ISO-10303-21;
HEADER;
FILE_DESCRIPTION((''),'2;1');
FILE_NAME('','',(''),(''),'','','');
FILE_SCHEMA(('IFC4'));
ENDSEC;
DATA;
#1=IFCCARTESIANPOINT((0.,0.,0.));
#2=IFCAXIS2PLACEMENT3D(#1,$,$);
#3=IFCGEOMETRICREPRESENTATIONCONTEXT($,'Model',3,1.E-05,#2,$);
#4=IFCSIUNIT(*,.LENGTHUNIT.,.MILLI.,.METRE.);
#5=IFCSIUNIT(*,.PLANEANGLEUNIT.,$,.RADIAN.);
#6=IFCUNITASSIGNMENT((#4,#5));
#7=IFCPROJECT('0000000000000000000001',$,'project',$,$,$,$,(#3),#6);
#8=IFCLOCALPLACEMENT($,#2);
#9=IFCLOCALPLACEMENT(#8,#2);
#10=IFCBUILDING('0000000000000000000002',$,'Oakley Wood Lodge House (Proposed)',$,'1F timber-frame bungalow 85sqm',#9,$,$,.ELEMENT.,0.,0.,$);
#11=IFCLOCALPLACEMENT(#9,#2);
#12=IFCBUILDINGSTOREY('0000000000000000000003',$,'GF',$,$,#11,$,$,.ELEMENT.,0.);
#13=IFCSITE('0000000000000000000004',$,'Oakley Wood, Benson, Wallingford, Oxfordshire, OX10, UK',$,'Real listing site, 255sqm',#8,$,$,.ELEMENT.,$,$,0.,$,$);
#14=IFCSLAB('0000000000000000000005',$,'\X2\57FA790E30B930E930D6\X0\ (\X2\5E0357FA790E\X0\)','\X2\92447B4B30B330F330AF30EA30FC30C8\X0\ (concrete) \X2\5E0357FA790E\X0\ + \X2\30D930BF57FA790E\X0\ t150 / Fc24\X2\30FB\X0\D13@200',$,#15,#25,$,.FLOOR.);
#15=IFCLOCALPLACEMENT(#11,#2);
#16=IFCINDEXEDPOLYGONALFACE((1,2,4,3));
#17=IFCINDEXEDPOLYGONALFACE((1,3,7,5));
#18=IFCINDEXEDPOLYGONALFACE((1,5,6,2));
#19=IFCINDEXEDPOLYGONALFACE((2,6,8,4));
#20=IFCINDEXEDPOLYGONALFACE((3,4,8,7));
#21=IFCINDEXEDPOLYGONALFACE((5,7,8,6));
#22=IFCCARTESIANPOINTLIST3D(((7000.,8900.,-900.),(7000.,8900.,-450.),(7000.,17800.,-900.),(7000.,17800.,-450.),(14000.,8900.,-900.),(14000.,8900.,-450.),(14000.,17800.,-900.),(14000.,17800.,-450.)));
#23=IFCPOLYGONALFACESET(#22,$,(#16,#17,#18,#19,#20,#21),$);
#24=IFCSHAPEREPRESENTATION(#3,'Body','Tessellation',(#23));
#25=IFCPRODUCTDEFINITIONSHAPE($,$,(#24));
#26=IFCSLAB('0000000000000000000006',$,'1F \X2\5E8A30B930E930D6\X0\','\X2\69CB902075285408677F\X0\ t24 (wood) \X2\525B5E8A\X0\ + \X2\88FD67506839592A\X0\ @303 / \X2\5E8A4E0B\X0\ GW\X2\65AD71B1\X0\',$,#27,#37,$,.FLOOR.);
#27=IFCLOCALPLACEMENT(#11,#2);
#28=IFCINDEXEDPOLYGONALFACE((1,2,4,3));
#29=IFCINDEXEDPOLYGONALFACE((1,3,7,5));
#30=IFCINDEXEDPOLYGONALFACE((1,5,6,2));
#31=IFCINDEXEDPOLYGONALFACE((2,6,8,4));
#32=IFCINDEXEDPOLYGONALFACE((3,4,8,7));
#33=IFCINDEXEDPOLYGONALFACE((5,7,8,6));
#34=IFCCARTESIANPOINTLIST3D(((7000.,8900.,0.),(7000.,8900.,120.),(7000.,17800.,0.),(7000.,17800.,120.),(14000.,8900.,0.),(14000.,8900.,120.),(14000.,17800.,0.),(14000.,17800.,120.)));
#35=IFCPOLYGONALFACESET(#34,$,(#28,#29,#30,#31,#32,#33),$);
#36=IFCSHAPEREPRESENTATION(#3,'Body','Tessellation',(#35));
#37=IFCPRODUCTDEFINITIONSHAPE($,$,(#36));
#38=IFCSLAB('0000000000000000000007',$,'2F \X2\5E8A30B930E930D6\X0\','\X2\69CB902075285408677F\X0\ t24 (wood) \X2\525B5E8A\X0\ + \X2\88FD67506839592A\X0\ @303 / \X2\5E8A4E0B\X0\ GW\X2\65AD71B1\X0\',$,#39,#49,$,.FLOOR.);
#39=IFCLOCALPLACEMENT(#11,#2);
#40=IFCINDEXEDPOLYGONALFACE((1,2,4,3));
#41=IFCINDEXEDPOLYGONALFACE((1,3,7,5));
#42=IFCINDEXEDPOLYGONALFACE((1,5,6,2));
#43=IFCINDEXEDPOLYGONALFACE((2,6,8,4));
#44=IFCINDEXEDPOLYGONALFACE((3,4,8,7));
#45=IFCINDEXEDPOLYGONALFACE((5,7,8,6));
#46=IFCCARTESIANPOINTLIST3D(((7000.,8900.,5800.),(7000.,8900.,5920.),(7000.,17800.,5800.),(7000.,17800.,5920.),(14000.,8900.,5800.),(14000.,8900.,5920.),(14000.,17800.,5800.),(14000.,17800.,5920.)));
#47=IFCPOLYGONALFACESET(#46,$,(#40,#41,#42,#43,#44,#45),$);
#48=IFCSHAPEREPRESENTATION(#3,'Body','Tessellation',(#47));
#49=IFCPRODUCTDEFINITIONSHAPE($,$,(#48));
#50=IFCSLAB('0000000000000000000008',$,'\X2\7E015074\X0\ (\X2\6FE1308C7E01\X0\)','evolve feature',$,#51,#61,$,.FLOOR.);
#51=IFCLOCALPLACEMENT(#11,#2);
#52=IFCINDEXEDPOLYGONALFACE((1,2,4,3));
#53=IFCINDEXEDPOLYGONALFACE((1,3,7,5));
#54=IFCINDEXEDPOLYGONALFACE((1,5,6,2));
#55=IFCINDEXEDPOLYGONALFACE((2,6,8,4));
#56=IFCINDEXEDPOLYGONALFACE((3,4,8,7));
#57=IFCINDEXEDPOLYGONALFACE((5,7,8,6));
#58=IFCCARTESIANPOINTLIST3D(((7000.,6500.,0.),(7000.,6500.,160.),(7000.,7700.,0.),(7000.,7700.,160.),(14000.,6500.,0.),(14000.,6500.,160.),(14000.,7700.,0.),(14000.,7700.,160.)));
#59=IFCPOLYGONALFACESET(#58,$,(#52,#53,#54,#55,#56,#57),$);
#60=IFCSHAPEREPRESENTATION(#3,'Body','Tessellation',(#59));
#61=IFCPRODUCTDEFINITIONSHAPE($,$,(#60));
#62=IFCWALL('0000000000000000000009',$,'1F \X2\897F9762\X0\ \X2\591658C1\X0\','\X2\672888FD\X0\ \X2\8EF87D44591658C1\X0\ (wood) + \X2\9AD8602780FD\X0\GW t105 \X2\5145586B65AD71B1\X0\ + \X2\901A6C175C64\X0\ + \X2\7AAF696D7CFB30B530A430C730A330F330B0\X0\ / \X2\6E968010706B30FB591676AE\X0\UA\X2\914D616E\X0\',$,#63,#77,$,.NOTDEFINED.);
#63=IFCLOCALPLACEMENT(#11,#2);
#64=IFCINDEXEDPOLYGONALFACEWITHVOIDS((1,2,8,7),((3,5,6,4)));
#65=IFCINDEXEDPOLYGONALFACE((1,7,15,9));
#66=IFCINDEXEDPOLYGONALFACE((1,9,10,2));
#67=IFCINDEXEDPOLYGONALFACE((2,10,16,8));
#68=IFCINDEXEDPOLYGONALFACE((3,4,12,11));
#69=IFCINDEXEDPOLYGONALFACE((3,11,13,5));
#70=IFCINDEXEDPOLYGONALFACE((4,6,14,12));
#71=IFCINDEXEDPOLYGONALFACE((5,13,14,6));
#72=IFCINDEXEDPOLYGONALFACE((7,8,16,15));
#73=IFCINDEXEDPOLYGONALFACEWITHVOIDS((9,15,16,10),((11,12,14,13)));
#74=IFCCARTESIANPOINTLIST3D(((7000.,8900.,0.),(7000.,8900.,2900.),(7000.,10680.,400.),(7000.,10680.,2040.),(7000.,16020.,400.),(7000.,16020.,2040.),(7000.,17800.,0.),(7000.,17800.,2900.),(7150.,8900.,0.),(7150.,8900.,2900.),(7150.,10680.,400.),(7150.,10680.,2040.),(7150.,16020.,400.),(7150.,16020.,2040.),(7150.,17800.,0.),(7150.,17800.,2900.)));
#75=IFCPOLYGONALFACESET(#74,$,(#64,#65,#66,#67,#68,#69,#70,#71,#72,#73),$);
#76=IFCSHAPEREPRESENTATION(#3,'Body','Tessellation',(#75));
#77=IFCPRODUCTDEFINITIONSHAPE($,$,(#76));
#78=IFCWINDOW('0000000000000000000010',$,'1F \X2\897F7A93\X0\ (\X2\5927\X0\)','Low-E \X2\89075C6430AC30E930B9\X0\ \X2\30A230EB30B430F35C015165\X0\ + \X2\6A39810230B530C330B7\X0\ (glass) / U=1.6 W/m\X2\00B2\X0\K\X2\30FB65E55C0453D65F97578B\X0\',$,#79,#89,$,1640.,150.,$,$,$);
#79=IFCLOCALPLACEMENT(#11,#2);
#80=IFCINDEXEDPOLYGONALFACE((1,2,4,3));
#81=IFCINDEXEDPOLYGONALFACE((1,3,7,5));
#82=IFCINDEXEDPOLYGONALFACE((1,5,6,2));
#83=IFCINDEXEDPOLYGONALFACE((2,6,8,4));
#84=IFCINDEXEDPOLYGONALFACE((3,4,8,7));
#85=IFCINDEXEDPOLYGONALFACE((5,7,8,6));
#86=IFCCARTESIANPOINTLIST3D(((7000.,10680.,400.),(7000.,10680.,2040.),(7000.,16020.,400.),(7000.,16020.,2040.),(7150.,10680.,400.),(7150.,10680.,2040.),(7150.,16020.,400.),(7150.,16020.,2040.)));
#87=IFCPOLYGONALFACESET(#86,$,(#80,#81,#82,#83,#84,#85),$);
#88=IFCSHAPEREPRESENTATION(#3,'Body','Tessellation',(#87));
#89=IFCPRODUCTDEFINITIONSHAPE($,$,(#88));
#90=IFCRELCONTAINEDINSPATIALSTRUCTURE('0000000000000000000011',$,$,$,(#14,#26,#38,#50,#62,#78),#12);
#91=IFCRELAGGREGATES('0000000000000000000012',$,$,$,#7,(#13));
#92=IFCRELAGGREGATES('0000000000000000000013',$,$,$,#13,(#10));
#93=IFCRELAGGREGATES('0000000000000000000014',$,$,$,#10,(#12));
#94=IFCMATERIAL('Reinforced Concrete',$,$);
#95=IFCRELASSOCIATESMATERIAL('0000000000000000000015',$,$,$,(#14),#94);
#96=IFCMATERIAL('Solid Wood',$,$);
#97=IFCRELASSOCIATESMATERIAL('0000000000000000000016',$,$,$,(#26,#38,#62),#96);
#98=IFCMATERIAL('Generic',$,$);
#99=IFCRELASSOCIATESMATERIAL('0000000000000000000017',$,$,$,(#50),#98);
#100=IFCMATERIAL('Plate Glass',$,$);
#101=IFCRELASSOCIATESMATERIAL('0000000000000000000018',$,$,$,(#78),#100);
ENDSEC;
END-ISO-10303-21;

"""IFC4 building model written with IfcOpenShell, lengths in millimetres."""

from ifc_helpers import new_model, si_unit, frame, frame_2d, origin, place, context, project, spatial, rectangle, extrude, material, element, fill, save


model = new_model("IFC4")

# Units and contexts
model_context = context("Model", 3, precision=1e-05, world=origin())
ifc_project = project(units=[si_unit("LENGTHUNIT", "METRE", prefix="MILLI"), si_unit("PLANEANGLEUNIT", "RADIAN")], contexts=[model_context])

# Site, building, storey
site_placement = place(None, origin())
site = spatial("IfcSite", under=ifc_project, at=site_placement, Name="Oakley Wood, Benson, Wallingford, Oxfordshire, OX10, UK", ObjectType="Real listing site, 255sqm", CompositionType="ELEMENT", RefElevation=0.0)
building_placement = place(site_placement, origin())
building = spatial("IfcBuilding", under=site, at=building_placement, Name="Oakley Wood Lodge House (Proposed)", ObjectType="1F timber-frame bungalow 85sqm", CompositionType="ELEMENT", ElevationOfRefHeight=0.0, ElevationOfTerrain=0.0)
storey_placement = place(building_placement, origin())
storey = spatial("IfcBuildingStorey", under=building, at=storey_placement, Name="GF", CompositionType="ELEMENT", Elevation=0.0)

# Slabs
ifc_material_1 = material(Name="Reinforced Concrete")
slab_1_placement = place(storey_placement, frame((3500.0, 4450.0, -450.0)))
element("IfcSlab", 1, at=slab_1_placement, inside=storey, material=ifc_material_1, Name="基礎スラブ (布基礎)", Description="鉄筋コンクリート (concrete) 布基礎 + ベタ基礎 t150 / Fc24・D13@200", PredefinedType="FLOOR", context=model_context, shape_type="SweptSolid", body=[
    extrude(rectangle(XDim=7000.0, YDim=8900.0, at=frame_2d((3500.0, 4450.0))), frame((3500.0, 4450.0, -450.0)), (0.0, 0.0, 1.0), 450.0),
])
ifc_material_2 = material(Name="Solid Wood")
slab_2_placement = place(storey_placement, frame((3500.0, 4450.0, 0.0)))
element("IfcSlab", 2, at=slab_2_placement, inside=storey, material=ifc_material_2, Name="1F 床スラブ", Description="構造用合板 t24 (wood) 剛床 + 製材根太 @303 / 床下 GW断熱", PredefinedType="FLOOR", context=model_context, shape_type="SweptSolid", body=[
    extrude(rectangle(XDim=7000.0, YDim=8900.0, at=frame_2d((3500.0, 4450.0))), frame((3500.0, 4450.0, 0.0)), (0.0, 0.0, 1.0), 120.0),
])
slab_3_placement = place(storey_placement, frame((3500.0, 4450.0, 2900.0)))
element("IfcSlab", 3, at=slab_3_placement, inside=storey, material=ifc_material_2, Name="2F 床スラブ", Description="構造用合板 t24 (wood) 剛床 + 製材根太 @303 / 床下 GW断熱", PredefinedType="FLOOR", context=model_context, shape_type="SweptSolid", body=[
    extrude(rectangle(XDim=7000.0, YDim=8900.0, at=frame_2d((3500.0, 4450.0))), frame((3500.0, 4450.0, 2900.0)), (0.0, 0.0, 1.0), 120.0),
])
ifc_material_3 = material(Name="Generic")
slab_4_placement = place(storey_placement, frame((3500.0, 3250.0, 0.0)))
element("IfcSlab", 4, at=slab_4_placement, inside=storey, material=ifc_material_3, Name="縁側 (濡れ縁)", Description="evolve feature", PredefinedType="FLOOR", context=model_context, shape_type="SweptSolid", body=[
    extrude(rectangle(XDim=7000.0, YDim=1200.0, at=frame_2d((3500.0, 600.0))), frame((3500.0, 3250.0, 0.0)), (0.0, 0.0, 1.0), 160.0),
])

# Shared definitions
ifc_material_4 = material(Name="Plate Glass")

# Wall, opening, window
wall_1_placement = place(storey_placement, frame((3500.0, 4450.0, 0.0)))
wall_1 = element("IfcWall", 5, at=wall_1_placement, inside=storey, material=ifc_material_2, Name="1F 西面 外壁", Description="木製 軸組外壁 (wood) + 高性能GW t105 充填断熱 + 通気層 + 窯業系サイディング / 準耐火・外皮UA配慮", PredefinedType="NOTDEFINED", context=model_context, shape_type="SweptSolid", body=[
    extrude(rectangle(XDim=150.0, YDim=8900.0, at=frame_2d((75.0, 4450.0))), frame((3500.0, 4450.0, 0.0)), (0.0, 0.0, 1.0), 2900.0),
])
opening_1_placement = place(storey_placement, frame((3500.0, 5340.0, 200.0)))
opening_1 = element("IfcOpeningElement", 6, at=opening_1_placement, cuts=wall_1, PredefinedType="NOTDEFINED", context=model_context, shape_type="SweptSolid", body=[
    extrude(rectangle(XDim=150.0, YDim=5340.0, at=frame_2d((75.0, 2670.0))), frame((3500.0, 5340.0, 200.0)), (0.0, 0.0, 1.0), 1640.0),
])
window_1_placement = place(storey_placement, frame((3500.0, 5340.0, 200.0)))
window_1 = element("IfcWindow", 7, at=window_1_placement, inside=storey, material=ifc_material_4, Name="1F 西窓 (大)", Description="Low-E 複層ガラス アルゴン封入 + 樹脂サッシ (glass) / U=1.6 W/m²K・日射取得型", OverallHeight=1640.0, OverallWidth=150.0, context=model_context, shape_type="SweptSolid", body=[
    extrude(rectangle(XDim=150.0, YDim=5340.0, at=frame_2d((75.0, 2670.0))), frame((3500.0, 5340.0, 200.0)), (0.0, 0.0, 1.0), 1640.0),
])
fill(opening_1, window_1)

save(model, "model.ifc")
